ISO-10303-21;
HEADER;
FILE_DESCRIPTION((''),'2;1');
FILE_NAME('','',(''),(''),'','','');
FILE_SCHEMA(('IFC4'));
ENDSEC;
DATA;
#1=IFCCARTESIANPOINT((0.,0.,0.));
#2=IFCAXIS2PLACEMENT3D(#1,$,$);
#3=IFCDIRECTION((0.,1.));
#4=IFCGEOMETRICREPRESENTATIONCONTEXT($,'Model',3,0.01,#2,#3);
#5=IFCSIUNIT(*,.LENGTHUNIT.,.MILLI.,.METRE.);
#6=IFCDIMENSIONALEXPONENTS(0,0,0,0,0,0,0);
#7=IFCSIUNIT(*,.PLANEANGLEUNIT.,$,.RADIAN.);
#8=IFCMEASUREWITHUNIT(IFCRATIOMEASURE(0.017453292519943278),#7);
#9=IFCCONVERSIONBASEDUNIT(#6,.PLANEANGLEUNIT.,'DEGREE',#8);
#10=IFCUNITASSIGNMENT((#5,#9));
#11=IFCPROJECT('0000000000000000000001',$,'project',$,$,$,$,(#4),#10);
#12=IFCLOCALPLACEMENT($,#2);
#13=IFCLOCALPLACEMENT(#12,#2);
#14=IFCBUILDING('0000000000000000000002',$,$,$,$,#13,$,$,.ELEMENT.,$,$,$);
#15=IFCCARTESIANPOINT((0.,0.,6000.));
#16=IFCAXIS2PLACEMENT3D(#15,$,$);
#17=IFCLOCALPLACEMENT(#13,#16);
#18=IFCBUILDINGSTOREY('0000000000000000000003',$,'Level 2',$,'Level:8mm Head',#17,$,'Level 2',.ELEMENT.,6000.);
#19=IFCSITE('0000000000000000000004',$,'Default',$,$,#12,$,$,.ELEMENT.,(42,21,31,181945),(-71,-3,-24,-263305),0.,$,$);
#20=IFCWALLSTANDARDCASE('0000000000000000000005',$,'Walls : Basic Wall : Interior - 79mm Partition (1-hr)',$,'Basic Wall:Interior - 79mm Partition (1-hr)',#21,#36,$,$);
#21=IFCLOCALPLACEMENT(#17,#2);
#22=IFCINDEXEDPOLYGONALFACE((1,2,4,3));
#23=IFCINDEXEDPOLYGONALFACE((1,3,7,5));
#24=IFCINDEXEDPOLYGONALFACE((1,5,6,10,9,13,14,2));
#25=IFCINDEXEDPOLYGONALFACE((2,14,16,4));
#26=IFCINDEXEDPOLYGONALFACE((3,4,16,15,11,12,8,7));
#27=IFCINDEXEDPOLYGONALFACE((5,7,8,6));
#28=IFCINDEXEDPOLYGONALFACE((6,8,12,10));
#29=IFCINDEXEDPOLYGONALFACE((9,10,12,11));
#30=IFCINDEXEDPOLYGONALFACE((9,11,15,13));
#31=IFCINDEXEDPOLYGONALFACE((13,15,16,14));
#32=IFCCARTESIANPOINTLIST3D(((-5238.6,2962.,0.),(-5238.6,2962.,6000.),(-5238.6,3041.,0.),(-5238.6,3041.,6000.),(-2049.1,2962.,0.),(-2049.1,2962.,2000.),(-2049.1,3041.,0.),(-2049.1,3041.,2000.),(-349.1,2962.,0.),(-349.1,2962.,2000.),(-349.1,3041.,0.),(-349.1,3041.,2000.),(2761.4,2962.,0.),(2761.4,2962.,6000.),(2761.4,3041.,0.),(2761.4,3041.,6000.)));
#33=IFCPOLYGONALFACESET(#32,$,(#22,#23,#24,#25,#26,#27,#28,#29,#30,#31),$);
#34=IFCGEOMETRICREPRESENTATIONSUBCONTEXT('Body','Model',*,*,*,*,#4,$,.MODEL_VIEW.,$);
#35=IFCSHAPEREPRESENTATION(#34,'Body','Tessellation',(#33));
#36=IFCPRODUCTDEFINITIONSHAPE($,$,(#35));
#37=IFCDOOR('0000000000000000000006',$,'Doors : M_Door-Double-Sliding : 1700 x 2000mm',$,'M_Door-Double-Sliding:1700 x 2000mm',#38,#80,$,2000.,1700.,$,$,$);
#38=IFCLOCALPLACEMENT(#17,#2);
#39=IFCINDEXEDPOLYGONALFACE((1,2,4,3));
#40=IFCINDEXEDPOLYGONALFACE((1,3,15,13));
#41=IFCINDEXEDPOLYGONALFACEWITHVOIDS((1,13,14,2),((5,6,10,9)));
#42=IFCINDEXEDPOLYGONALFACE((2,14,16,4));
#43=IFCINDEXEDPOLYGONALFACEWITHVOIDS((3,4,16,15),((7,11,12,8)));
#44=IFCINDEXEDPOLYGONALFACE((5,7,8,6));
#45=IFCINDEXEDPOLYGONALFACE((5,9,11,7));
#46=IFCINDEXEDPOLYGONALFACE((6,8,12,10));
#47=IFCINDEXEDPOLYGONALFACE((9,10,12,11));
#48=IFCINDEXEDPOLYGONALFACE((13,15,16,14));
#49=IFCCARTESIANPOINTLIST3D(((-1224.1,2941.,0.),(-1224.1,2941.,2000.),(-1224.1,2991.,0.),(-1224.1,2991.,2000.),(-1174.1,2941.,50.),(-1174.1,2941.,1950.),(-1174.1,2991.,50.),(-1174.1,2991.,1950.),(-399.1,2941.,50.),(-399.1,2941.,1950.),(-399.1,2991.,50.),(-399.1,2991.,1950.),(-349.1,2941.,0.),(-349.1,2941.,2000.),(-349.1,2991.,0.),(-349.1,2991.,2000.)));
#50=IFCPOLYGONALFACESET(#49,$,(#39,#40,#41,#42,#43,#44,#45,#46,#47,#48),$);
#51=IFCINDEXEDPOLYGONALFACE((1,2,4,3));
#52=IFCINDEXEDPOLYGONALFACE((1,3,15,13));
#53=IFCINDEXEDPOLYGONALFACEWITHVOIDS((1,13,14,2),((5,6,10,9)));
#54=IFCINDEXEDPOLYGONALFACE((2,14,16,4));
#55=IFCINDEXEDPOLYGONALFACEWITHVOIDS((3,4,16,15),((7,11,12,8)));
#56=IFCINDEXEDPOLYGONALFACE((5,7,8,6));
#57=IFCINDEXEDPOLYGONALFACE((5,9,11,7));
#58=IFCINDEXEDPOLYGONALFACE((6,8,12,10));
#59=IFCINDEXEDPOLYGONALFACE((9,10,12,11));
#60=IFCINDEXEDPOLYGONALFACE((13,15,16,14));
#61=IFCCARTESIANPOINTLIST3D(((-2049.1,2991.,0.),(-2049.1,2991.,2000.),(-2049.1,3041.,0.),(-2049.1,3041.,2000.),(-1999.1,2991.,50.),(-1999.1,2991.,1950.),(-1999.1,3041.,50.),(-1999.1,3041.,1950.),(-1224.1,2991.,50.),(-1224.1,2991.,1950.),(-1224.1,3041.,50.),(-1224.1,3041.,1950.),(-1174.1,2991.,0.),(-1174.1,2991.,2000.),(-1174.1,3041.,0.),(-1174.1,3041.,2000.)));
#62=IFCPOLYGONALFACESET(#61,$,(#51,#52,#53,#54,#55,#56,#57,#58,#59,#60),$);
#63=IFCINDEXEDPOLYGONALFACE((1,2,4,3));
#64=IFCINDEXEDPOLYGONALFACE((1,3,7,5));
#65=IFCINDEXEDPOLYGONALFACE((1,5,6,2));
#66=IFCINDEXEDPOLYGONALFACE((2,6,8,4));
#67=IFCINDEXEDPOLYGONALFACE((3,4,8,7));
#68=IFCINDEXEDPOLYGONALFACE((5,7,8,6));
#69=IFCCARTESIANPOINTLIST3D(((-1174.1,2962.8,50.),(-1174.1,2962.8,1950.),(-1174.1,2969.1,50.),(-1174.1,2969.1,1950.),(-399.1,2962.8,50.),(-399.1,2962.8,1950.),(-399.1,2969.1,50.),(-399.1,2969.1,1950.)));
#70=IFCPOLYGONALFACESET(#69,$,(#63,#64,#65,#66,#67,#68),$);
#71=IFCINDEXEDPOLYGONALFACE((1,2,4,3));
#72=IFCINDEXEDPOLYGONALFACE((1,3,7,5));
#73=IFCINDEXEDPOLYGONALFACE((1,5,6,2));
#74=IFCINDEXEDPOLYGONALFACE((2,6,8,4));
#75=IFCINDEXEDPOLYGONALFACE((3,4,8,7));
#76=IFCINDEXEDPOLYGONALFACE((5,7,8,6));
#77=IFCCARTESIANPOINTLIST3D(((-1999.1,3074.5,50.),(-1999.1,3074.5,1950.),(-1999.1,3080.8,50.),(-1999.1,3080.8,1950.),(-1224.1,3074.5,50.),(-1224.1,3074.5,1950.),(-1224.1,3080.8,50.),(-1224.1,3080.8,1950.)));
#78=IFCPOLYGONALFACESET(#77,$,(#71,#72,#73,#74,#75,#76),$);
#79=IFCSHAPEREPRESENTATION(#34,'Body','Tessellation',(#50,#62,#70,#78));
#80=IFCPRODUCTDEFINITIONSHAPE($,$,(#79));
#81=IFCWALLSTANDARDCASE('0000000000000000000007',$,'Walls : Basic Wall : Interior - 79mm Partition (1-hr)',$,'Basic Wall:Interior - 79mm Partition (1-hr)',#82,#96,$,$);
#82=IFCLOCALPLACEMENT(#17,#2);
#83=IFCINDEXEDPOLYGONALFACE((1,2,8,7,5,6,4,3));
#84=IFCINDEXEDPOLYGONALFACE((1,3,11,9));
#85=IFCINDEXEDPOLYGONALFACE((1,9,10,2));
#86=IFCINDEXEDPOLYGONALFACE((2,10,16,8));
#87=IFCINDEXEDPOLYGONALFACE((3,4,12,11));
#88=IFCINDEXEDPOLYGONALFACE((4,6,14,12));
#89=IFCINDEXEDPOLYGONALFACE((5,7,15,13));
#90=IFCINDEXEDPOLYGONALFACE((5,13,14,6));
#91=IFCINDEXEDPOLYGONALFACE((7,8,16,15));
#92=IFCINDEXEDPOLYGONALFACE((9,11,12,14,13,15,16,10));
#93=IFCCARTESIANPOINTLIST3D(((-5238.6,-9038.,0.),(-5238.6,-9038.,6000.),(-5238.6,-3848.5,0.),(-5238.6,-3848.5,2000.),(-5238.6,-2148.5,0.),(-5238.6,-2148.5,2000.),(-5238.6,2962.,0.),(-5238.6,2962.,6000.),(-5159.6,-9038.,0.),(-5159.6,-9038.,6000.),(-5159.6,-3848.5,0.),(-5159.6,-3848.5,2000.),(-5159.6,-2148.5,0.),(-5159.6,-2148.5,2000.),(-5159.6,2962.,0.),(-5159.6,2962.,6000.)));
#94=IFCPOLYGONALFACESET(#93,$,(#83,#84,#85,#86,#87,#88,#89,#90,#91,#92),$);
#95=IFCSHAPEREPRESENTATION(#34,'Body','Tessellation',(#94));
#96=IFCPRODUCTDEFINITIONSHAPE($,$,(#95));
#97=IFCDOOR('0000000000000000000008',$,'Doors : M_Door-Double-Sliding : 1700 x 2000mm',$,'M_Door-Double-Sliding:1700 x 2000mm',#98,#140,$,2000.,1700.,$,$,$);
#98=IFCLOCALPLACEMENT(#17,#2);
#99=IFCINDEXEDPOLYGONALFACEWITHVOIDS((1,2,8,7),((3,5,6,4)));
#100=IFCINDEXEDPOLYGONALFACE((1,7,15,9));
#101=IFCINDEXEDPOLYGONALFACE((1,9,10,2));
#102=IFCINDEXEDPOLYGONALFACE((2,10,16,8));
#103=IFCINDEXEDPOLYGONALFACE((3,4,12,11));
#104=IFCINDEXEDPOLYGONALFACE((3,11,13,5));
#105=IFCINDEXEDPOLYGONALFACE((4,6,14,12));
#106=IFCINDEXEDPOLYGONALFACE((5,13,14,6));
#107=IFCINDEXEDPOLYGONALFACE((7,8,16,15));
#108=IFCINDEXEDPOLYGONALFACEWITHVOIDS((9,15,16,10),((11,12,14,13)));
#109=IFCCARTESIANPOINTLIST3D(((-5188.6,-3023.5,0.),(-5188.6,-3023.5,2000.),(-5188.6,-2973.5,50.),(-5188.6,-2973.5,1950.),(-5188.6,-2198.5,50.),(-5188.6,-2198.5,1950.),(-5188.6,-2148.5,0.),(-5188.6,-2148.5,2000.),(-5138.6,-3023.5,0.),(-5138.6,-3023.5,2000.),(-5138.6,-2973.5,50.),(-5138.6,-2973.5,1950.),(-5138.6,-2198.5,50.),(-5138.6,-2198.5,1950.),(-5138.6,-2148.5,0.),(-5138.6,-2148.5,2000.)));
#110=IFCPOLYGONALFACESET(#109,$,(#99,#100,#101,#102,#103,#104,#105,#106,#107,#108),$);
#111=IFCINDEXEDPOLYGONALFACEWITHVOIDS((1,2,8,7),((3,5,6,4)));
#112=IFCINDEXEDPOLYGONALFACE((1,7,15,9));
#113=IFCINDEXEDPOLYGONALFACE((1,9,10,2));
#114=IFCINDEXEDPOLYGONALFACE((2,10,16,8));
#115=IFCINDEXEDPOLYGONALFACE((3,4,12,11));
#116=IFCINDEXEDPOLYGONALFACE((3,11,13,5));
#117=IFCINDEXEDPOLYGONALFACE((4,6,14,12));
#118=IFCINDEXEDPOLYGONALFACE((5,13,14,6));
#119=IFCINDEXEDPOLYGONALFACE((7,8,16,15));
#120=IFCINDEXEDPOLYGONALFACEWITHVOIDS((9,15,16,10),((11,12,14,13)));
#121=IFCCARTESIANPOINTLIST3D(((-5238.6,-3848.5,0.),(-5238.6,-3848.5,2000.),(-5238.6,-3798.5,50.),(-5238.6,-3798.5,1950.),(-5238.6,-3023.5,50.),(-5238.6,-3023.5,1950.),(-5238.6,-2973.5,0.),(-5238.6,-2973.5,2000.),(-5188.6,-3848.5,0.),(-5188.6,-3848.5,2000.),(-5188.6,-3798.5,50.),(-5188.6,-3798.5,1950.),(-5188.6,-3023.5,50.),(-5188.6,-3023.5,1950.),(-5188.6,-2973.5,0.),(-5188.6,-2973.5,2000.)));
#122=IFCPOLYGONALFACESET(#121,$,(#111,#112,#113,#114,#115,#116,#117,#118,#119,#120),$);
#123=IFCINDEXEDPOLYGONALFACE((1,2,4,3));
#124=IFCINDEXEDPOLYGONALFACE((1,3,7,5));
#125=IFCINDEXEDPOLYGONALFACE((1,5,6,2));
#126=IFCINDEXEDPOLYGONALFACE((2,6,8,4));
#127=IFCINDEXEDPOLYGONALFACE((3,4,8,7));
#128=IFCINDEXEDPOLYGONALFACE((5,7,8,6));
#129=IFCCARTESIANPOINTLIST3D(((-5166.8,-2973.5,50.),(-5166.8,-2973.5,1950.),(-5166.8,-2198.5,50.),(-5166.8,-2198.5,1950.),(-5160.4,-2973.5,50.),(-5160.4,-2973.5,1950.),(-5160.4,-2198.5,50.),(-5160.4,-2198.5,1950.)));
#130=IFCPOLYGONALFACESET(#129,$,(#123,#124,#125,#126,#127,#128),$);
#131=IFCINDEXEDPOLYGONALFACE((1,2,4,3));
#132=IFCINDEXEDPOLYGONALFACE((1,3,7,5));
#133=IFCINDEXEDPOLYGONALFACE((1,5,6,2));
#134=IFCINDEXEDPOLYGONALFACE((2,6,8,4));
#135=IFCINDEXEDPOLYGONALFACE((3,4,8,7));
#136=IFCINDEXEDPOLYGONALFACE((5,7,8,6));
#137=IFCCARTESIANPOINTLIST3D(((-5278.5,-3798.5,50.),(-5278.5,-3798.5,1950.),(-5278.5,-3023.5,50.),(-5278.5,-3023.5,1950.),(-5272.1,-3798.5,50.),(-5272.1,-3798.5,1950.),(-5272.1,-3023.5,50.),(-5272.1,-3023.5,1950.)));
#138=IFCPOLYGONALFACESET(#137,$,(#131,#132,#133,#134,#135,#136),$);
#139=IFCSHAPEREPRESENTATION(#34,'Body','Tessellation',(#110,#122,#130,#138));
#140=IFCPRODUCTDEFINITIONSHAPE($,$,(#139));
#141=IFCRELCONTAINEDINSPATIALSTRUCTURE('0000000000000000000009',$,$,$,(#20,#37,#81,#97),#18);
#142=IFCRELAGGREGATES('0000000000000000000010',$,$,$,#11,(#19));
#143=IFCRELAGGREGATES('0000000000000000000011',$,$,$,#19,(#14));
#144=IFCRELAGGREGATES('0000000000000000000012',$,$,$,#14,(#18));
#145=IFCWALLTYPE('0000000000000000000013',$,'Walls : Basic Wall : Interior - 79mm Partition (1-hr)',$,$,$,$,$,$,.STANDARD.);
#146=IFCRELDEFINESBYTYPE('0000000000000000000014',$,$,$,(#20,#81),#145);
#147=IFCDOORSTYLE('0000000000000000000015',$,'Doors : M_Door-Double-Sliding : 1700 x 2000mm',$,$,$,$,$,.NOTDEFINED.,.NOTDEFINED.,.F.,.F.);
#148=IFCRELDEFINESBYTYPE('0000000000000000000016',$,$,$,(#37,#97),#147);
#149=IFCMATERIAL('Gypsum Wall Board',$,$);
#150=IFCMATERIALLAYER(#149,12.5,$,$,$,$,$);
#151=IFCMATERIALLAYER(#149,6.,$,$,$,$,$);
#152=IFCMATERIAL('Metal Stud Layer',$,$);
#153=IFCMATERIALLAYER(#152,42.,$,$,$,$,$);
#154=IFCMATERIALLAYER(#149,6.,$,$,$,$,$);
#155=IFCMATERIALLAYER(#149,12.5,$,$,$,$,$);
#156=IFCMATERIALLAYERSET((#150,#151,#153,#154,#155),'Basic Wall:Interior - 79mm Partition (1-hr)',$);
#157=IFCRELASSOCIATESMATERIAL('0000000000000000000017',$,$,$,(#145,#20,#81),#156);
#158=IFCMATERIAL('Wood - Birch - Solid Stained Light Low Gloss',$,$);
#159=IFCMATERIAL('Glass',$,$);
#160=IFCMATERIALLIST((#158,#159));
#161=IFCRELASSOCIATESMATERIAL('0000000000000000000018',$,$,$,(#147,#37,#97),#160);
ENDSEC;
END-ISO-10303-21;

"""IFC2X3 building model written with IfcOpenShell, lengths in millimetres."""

from ifc_helpers import new_model, entity, si_unit, converted_unit, direction, frame, frame_2d, origin, origin_2d_with_axis, place, context, subcontext, project, spatial, polyline, rectangle, outline, extrude, source, transform, mapped, material, material_list, layer, layer_set, layer_usage, type_object, type_shapes, element, fill, save


model = new_model("IFC2X3")

# Units and contexts
model_context = context("Model", 3, precision=0.01, world=origin(), true_north=direction((0.0, 1.0)))
body_context = subcontext(model_context, "Body", "Model", "MODEL_VIEW")
ifc_project = project(units=[si_unit("LENGTHUNIT", "METRE", prefix="MILLI"), converted_unit("PLANEANGLEUNIT", "DEGREE", entity("IfcRatioMeasure", 0.017453292519943278), si_unit("PLANEANGLEUNIT", "RADIAN"), dimensions=[0, 0, 0, 0, 0, 0, 0])], contexts=[model_context])

# Site, building, storey
site_placement = place(None, origin())
site = spatial("IfcSite", under=ifc_project, at=site_placement, Name="Default", CompositionType="ELEMENT", RefLatitude=(42, 21, 31, 181945), RefLongitude=(-71, -3, -24, -263305), RefElevation=0.0)
building_placement = place(site_placement, origin())
building = spatial("IfcBuilding", under=site, at=building_placement, CompositionType="ELEMENT")
storey_placement = place(building_placement, frame((0.0, 0.0, 6000.0)))
storey = spatial("IfcBuildingStorey", under=building, at=storey_placement, Name="Level 2", ObjectType="Level:8mm Head", LongName="Level 2", CompositionType="ELEMENT", Elevation=6000.0)

# Shared definitions
ifc_material_1 = material(Name="Metal Stud Layer")
ifc_material_2 = material(Name="Gypsum Wall Board")
ifc_layer_1 = layer(ifc_material_2, 12.5)
ifc_layer_2 = layer(ifc_material_2, 6.0)
ifc_layer_3 = layer(ifc_material_1, 42.0)
ifc_layer_4 = layer(ifc_material_2, 6.0)
ifc_layer_5 = layer(ifc_material_2, 12.5)
ifc_layer_set_1 = layer_set([ifc_layer_1, ifc_layer_2, ifc_layer_3, ifc_layer_4, ifc_layer_5], Name="Basic Wall:Interior - 79mm Partition (1-hr)")
ifc_layer_usage_1 = layer_usage(ifc_layer_set_1, "AXIS2", "NEGATIVE", 39.5)
wall_type_1 = type_object("IfcWallType", Name="Walls : Basic Wall : Interior - 79mm Partition (1-hr)", PredefinedType="STANDARD", material=ifc_layer_set_1)

# Walls, openings, doors
wall_1_placement = place(storey_placement, frame((2761.4, 3001.5, 0.0), z_axis=(0.0, 0.0, 1.0), x_axis=(-1.0, 0.0, 0.0)))
wall_1 = element("IfcWallStandardCase", 1, at=wall_1_placement, inside=storey, type_object=wall_type_1, material=ifc_layer_usage_1, Name="Walls : Basic Wall : Interior - 79mm Partition (1-hr)", ObjectType="Basic Wall:Interior - 79mm Partition (1-hr)", context=body_context, shape_type="SweptSolid", body=[
    extrude(rectangle(XDim=8000.0, YDim=79.0, at=frame_2d((4000.0, 0.0), x_axis=(1.0, 0.0))), origin(), (0.0, 0.0, 1.0), 6000.0),
])
opening_1_placement = place(wall_1_placement, frame((4810.5, 39.5, 0.0)))
opening_1 = element("IfcOpeningElement", 2, at=opening_1_placement, cuts=wall_1, ObjectType="Opening", context=body_context, shape_type="SweptSolid", body=[
    extrude(rectangle(XDim=2000.0, YDim=1700.0, at=frame_2d((1000.0, 850.0), x_axis=(-1.0, 0.0))), frame((0.0, 0.0, 0.0), z_axis=(0.0, -1.0, 0.0), x_axis=(0.0, 0.0, 1.0)), (0.0, 0.0, 1.0), 79.0),
])
ifc_material_3 = material(Name="Wood - Birch - Solid Stained Light Low Gloss")
ifc_material_4 = material(Name="Glass")
ifc_material_list = material_list([ifc_material_3, ifc_material_4])
door_style = type_object("IfcDoorStyle", Name="Doors : M_Door-Double-Sliding : 1700 x 2000mm", ConstructionType="NOTDEFINED", OperationType="NOTDEFINED", ParameterTakesPrecedence=False, Sizeable=False, material=ifc_material_list)
shared_shape = source(origin(), body_context, "Body", "SweptSolid", [
    extrude(outline(polyline([(-437.5, -1000.0), (437.5, -1000.0), (437.5, 1000.0), (-437.5, 1000.0), (-437.5, -1000.0)]), holes=[polyline([(-387.5, -950.0), (-387.5, 950.0), (387.5, 950.0), (387.5, -950.0), (-387.5, -950.0)])]), frame((1262.5, -21.0, 1000.0), z_axis=(0.0, 1.0, 0.0), x_axis=(1.0, 0.0, 0.0)), (0.0, 0.0, 1.0), 50.0),
    extrude(outline(polyline([(-1000.0, -437.5), (1000.0, -437.5), (1000.0, 437.5), (-1000.0, 437.5), (-1000.0, -437.5)]), holes=[polyline([(-950.0, -387.5), (-950.0, 387.5), (950.0, 387.5), (950.0, -387.5), (-950.0, -387.5)])]), frame((437.5, 29.0, 1000.0), z_axis=(0.0, 1.0, 0.0), x_axis=(0.0, 0.0, -1.0)), (0.0, 0.0, 1.0), 50.0),
    extrude(rectangle(XDim=6.3, YDim=775.0, at=frame_2d((0.0, 0.0), x_axis=(1.0, 0.0))), frame((1262.5, 4.0, 50.0), z_axis=(0.0, 0.0, 1.0), x_axis=(0.0, -1.0, 0.0)), (0.0, 0.0, 1.0), 1900.0),
    extrude(rectangle(XDim=6.4, YDim=775.0, at=origin_2d_with_axis()), frame((437.5, 115.7, 50.0), z_axis=(0.0, 0.0, 1.0), x_axis=(0.0, 1.0, 0.0)), (0.0, 0.0, 1.0), 1900.0),
])
type_shapes(door_style, [shared_shape])
door_1_placement = place(opening_1_placement, frame((0.0, 0.0, 0.0), z_axis=(0.0, 0.0, 1.0), x_axis=(-1.0, 0.0, 0.0)))
door_1 = element("IfcDoor", 3, at=door_1_placement, inside=storey, type_object=door_style, material=ifc_material_list, Name="Doors : M_Door-Double-Sliding : 1700 x 2000mm", ObjectType="M_Door-Double-Sliding:1700 x 2000mm", OverallHeight=2000.0, OverallWidth=1700.0, context=body_context, shape_type="MappedRepresentation", body=[
    mapped(shared_shape, transform((0.0, 0.0, 0.0), scale=1.0)),
])
fill(opening_1, door_1)
wall_2_placement = place(storey_placement, frame((-5199.1, 2962.0, 0.0), z_axis=(0.0, 0.0, 1.0), x_axis=(0.0, -1.0, 0.0)))
wall_2 = element("IfcWallStandardCase", 4, at=wall_2_placement, inside=storey, type_object=wall_type_1, material=ifc_layer_usage_1, Name="Walls : Basic Wall : Interior - 79mm Partition (1-hr)", ObjectType="Basic Wall:Interior - 79mm Partition (1-hr)", context=body_context, shape_type="SweptSolid", body=[
    extrude(rectangle(XDim=12000.0, YDim=79.0, at=frame_2d((6000.0, 0.0), x_axis=(1.0, 0.0))), origin(), (0.0, 0.0, 1.0), 6000.0),
])
opening_2_placement = place(wall_2_placement, frame((6810.5, 39.5, 0.0)))
opening_2 = element("IfcOpeningElement", 5, at=opening_2_placement, cuts=wall_2, ObjectType="Opening", context=body_context, shape_type="SweptSolid", body=[
    extrude(rectangle(XDim=2000.0, YDim=1700.0, at=frame_2d((1000.0, 850.0), x_axis=(-1.0, 0.0))), frame((0.0, 0.0, 0.0), z_axis=(0.0, -1.0, 0.0), x_axis=(0.0, 0.0, 1.0)), (0.0, 0.0, 1.0), 79.0),
])
door_2_placement = place(opening_2_placement, frame((0.0, 0.0, 0.0), z_axis=(0.0, 0.0, 1.0), x_axis=(-1.0, 0.0, 0.0)))
door_2 = element("IfcDoor", 6, at=door_2_placement, inside=storey, type_object=door_style, material=ifc_material_list, Name="Doors : M_Door-Double-Sliding : 1700 x 2000mm", ObjectType="M_Door-Double-Sliding:1700 x 2000mm", OverallHeight=2000.0, OverallWidth=1700.0, context=body_context, shape_type="MappedRepresentation", body=[
    mapped(shared_shape, transform((0.0, 0.0, 0.0), scale=1.0)),
])
fill(opening_2, door_2)

save(model, "model.ifc")
